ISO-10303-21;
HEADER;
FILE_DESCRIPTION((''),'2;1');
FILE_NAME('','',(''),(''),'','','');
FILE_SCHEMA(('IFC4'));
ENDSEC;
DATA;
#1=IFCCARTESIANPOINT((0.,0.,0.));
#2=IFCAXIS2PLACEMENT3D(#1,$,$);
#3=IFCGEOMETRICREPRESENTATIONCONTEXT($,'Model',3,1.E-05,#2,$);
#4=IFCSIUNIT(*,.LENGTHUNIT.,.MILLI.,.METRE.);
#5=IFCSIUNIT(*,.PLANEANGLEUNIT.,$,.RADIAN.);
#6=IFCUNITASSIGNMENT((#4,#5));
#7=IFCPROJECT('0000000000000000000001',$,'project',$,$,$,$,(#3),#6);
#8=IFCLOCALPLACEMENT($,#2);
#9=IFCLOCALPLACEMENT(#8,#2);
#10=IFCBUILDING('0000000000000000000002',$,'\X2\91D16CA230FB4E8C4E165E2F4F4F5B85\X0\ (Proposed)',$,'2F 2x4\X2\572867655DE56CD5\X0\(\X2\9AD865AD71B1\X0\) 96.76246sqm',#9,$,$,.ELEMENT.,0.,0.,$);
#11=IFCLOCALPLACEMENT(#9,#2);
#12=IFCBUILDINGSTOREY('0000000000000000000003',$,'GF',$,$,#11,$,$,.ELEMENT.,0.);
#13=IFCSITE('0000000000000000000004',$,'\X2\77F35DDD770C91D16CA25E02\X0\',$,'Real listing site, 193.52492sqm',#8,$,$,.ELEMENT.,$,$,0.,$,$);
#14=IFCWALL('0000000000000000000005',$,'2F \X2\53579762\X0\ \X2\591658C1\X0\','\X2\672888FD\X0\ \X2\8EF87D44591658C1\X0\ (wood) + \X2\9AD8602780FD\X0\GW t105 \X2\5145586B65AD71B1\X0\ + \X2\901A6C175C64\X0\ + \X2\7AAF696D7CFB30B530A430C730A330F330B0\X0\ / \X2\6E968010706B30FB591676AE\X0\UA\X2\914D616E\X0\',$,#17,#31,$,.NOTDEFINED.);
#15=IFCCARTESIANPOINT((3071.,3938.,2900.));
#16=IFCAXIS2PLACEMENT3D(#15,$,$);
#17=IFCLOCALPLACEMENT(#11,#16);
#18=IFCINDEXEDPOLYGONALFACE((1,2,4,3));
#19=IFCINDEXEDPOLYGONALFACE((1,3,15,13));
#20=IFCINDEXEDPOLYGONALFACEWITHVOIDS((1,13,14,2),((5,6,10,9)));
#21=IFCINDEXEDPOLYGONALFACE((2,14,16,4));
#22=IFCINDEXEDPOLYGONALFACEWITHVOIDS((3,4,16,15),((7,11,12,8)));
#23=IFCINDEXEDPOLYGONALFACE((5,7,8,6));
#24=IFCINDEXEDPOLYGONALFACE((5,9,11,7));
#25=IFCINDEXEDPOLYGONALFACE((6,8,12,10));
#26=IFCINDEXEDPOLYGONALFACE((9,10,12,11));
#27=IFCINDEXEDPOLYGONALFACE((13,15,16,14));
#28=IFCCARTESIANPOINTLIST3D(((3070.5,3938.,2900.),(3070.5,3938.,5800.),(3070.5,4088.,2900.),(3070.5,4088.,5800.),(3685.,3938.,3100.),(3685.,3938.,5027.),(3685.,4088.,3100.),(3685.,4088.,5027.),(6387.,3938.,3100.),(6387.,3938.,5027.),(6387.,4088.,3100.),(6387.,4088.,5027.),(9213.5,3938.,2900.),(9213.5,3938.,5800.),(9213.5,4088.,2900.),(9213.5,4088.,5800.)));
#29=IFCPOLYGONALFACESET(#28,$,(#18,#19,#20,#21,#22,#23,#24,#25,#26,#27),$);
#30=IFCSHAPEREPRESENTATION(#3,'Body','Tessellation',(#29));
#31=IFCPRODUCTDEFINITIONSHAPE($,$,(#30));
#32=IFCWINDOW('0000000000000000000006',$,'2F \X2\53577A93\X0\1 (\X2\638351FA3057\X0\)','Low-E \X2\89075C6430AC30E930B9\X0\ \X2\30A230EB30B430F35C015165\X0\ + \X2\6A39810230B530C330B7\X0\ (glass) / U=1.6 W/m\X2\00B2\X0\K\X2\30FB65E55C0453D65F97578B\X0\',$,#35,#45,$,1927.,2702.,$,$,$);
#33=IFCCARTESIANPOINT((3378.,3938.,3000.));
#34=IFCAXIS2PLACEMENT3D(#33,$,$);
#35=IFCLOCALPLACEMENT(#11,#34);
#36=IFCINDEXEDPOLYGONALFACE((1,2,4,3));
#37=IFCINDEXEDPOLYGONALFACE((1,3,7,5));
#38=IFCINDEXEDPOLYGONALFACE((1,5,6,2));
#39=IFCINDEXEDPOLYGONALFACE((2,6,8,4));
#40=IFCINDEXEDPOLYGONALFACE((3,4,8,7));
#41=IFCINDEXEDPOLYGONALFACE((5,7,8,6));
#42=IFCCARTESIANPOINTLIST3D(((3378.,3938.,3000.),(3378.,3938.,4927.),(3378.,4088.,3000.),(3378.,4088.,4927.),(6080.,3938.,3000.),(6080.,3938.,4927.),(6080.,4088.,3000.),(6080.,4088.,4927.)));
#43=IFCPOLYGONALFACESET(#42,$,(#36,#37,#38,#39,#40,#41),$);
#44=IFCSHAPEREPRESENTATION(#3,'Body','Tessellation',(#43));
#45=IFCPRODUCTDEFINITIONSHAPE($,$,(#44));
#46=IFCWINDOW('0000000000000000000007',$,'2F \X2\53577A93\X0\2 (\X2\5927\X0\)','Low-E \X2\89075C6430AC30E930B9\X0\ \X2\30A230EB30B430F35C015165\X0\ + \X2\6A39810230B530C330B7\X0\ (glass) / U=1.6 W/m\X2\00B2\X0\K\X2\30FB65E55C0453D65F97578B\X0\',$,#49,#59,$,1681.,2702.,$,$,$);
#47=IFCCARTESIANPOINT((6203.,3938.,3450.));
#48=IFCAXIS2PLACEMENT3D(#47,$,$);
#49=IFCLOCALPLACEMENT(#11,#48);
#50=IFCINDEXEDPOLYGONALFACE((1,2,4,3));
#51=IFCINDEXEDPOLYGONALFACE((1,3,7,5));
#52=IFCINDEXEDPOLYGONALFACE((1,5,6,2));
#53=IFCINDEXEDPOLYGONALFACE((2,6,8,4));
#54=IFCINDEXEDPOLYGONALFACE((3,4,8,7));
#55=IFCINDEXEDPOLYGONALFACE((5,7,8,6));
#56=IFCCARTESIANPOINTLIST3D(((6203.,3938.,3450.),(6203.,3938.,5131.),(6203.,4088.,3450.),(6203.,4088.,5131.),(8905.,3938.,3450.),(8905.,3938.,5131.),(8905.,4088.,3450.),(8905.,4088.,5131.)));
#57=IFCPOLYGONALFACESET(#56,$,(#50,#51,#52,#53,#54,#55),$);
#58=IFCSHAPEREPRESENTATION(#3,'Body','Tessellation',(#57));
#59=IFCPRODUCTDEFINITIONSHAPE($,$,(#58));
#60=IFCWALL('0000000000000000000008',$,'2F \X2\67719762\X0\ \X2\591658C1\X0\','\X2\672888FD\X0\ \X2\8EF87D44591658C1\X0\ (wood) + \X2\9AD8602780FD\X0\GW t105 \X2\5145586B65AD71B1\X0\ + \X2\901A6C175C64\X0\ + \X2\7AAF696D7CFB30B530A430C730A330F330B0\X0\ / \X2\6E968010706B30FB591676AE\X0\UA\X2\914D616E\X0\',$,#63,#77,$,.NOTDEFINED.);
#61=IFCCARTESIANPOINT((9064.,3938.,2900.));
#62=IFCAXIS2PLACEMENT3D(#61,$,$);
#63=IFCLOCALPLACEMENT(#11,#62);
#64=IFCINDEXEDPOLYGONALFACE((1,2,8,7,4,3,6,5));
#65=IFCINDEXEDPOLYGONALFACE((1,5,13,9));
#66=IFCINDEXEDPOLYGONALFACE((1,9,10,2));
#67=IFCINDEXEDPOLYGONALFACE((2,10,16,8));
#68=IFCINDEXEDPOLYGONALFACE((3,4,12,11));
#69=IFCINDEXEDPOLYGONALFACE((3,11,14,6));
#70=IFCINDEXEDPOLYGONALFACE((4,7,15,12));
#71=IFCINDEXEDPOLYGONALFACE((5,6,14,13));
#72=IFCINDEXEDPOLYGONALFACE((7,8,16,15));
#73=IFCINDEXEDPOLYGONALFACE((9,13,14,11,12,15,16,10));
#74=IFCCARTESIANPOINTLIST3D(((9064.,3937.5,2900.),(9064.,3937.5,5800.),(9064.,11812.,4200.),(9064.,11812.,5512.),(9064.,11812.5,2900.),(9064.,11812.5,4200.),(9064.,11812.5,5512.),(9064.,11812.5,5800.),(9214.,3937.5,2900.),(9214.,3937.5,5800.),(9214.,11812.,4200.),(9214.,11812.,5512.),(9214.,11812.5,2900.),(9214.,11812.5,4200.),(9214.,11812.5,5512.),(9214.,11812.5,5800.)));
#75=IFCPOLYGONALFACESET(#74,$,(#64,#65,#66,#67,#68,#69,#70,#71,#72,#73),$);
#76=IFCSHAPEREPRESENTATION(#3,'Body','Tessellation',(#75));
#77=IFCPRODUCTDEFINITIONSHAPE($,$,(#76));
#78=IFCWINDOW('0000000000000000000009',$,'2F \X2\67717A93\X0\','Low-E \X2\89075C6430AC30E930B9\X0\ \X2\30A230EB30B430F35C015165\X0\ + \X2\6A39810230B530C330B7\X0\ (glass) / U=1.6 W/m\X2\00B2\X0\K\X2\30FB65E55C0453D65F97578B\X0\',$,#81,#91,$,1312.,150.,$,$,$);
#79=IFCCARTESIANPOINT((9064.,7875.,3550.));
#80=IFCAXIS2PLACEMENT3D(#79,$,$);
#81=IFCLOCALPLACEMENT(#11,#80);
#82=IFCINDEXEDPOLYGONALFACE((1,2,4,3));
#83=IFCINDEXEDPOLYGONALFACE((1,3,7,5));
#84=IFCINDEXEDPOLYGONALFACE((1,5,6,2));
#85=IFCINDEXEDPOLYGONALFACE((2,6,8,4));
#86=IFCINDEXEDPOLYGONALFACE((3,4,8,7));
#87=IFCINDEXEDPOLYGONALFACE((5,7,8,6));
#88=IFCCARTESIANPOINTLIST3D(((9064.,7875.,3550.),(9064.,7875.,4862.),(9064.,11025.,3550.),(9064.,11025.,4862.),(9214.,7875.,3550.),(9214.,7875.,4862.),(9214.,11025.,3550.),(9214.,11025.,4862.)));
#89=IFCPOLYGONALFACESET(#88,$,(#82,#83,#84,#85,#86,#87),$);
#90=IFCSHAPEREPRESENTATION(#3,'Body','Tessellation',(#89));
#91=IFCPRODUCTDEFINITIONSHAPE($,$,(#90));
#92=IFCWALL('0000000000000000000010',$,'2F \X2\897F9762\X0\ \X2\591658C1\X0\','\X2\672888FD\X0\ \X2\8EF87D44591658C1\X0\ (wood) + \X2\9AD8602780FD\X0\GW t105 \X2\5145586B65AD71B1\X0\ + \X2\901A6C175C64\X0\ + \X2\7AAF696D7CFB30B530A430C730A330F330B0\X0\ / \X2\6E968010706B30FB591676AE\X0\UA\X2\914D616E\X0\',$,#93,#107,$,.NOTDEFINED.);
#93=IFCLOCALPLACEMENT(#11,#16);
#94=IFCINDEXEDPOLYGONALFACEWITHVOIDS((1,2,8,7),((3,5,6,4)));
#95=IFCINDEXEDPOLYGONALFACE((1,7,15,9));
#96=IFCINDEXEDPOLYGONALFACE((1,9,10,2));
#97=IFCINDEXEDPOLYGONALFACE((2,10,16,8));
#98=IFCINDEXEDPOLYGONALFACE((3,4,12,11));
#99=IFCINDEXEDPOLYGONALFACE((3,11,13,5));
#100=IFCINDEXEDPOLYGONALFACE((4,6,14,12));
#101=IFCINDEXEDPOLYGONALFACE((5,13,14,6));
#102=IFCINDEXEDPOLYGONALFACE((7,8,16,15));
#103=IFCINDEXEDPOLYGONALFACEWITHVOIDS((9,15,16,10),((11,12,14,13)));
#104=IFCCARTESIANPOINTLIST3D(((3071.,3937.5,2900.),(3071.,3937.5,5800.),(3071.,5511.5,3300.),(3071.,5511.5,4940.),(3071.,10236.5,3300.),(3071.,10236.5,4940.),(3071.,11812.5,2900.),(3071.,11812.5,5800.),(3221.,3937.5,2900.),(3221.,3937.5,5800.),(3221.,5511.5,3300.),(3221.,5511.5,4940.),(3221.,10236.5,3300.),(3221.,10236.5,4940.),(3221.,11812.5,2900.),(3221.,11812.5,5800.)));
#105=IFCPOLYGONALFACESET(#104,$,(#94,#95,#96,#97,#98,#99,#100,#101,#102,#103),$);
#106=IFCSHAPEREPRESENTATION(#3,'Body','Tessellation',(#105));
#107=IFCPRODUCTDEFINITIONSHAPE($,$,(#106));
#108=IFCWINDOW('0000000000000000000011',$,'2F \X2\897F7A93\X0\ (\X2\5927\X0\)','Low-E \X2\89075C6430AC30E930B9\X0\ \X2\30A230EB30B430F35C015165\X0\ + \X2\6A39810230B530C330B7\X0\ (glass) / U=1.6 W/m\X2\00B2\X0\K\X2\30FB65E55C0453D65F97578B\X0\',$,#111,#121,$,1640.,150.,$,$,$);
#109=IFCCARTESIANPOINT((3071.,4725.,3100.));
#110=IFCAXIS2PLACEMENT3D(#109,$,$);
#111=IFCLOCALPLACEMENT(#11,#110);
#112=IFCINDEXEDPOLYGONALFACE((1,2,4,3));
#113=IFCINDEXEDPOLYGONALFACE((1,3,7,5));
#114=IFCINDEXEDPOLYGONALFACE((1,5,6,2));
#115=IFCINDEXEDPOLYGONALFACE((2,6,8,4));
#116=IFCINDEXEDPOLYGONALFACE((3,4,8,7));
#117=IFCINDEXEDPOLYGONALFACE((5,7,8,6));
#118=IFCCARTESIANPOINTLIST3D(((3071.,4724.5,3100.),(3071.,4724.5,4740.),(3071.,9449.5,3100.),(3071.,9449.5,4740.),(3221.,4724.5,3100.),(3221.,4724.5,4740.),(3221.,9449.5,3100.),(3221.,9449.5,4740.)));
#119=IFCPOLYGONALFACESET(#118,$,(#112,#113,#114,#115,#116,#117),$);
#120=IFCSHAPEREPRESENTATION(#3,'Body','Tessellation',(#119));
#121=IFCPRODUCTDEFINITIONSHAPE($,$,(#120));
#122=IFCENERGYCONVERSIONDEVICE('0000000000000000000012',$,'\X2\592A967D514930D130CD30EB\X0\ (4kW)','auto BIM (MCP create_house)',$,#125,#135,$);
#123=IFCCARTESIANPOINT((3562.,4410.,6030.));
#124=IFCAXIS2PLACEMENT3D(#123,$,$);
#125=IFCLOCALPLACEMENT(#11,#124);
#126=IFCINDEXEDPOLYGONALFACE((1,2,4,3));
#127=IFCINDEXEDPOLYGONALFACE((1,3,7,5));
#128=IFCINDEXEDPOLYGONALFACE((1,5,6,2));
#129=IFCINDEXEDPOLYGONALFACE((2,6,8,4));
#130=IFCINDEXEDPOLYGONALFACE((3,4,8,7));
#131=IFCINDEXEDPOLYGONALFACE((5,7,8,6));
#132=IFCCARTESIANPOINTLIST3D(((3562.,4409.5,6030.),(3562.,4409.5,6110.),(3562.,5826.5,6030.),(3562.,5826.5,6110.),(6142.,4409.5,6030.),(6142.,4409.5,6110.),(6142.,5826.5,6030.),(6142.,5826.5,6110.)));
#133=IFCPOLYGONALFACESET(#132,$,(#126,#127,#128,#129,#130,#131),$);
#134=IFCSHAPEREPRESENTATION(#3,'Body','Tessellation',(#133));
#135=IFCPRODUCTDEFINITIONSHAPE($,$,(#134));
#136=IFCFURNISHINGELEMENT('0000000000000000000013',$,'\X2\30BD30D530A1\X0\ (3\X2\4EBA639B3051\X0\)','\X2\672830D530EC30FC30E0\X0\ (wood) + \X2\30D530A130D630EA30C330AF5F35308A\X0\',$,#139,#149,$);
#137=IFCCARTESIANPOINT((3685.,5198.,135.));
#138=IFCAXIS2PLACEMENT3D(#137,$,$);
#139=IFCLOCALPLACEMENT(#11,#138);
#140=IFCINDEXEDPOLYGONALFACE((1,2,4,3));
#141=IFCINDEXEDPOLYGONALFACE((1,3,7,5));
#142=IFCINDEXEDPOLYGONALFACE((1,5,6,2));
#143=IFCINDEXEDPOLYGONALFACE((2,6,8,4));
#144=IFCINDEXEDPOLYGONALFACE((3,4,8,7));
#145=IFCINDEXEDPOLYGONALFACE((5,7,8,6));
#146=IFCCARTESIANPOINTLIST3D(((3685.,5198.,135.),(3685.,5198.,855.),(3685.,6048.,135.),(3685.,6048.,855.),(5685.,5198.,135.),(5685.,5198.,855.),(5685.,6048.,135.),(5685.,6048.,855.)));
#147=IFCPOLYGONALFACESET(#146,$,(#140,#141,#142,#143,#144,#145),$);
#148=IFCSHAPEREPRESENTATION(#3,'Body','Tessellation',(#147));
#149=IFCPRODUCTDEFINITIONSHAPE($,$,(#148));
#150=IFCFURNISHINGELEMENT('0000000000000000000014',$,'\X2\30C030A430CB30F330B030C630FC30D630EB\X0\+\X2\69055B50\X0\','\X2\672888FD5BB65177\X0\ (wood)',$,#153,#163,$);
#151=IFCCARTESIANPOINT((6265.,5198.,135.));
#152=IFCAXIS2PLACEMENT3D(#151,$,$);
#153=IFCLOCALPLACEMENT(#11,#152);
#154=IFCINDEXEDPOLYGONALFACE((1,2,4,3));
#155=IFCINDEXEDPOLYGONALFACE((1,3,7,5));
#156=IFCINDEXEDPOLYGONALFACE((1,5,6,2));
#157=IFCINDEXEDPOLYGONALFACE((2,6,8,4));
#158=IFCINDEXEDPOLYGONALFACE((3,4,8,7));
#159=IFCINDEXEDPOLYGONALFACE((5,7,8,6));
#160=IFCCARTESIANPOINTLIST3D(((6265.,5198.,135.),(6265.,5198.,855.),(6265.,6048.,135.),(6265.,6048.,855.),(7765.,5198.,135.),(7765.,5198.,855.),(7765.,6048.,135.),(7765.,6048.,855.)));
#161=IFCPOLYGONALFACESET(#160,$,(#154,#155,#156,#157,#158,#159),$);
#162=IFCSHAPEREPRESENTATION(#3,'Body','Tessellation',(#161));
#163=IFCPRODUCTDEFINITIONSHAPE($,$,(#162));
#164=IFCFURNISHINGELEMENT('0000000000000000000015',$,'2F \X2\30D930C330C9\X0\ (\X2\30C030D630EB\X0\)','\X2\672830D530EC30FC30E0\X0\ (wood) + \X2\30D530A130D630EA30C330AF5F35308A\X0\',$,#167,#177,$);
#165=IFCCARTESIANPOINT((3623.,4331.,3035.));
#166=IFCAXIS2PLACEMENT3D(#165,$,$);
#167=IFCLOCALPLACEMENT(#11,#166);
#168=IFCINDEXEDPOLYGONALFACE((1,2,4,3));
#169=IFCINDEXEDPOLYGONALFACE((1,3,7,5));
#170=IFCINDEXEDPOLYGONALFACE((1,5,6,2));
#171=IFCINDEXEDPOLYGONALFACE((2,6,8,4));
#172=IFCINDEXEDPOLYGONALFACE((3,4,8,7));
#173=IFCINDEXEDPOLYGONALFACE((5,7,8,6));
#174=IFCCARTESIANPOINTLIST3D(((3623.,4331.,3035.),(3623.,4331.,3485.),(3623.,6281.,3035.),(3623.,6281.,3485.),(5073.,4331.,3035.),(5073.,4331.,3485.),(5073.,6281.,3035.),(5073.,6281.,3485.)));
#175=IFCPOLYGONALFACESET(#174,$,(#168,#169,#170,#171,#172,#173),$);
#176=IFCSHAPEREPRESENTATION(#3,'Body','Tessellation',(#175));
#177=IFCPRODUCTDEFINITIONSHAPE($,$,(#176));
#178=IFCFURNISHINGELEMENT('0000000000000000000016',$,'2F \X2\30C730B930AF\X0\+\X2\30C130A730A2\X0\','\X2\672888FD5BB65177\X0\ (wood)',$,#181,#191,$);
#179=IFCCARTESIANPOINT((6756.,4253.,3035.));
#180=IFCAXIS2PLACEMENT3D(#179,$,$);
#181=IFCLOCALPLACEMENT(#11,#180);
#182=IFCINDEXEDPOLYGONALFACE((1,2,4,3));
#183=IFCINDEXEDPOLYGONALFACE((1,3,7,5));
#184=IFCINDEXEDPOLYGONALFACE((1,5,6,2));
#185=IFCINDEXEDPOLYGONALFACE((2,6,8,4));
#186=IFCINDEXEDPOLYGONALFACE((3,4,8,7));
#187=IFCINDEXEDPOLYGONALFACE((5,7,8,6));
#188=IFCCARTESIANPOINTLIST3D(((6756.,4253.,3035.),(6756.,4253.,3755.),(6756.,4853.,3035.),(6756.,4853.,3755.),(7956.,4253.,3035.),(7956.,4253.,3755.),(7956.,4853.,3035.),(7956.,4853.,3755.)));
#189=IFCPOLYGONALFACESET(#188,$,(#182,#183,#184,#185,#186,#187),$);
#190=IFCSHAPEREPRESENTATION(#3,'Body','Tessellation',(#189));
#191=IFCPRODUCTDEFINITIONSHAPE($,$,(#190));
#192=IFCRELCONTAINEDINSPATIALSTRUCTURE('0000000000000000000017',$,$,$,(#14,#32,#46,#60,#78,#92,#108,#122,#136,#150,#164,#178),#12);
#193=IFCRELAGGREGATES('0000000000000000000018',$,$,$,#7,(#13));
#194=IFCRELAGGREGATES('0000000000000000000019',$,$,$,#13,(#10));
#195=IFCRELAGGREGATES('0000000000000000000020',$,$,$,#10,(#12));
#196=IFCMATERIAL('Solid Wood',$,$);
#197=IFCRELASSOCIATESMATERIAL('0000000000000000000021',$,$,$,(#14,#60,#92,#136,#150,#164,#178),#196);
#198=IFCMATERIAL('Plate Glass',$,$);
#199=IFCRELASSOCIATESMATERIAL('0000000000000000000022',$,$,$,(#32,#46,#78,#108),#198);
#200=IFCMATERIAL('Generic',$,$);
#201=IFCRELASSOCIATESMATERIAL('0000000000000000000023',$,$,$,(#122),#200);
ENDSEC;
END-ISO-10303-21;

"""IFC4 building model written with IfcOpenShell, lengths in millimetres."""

from ifc_helpers import new_model, si_unit, frame, frame_2d, origin, place, context, project, spatial, rectangle, extrude, material, element, fill, save


model = new_model("IFC4")

# Units and contexts
model_context = context("Model", 3, precision=1e-05, world=origin())
ifc_project = project(units=[si_unit("LENGTHUNIT", "METRE", prefix="MILLI"), si_unit("PLANEANGLEUNIT", "RADIAN")], contexts=[model_context])

# Site, building, storey
site_placement = place(None, origin())
site = spatial("IfcSite", under=ifc_project, at=site_placement, Name="石川県金沢市", ObjectType="Real listing site, 193.52492sqm", CompositionType="ELEMENT", RefElevation=0.0)
building_placement = place(site_placement, origin())
building = spatial("IfcBuilding", under=site, at=building_placement, Name="金沢・二世帯住宅 (Proposed)", ObjectType="2F 2x4在来工法(高断熱) 96.76246sqm", CompositionType="ELEMENT", ElevationOfRefHeight=0.0, ElevationOfTerrain=0.0)
storey_placement = place(building_placement, origin())
storey = spatial("IfcBuildingStorey", under=building, at=storey_placement, Name="GF", CompositionType="ELEMENT", Elevation=0.0)

# Shared definitions
ifc_material_1 = material(Name="Solid Wood")

# Wall, openings, windows
wall_1_placement = place(storey_placement, frame((3071.0, 3938.0, 2900.0)))
wall_1 = element("IfcWall", 1, at=wall_1_placement, inside=storey, material=ifc_material_1, Name="2F 南面 外壁", Description="木製 軸組外壁 (wood) + 高性能GW t105 充填断熱 + 通気層 + 窯業系サイディング / 準耐火・外皮UA配慮", PredefinedType="NOTDEFINED", context=model_context, shape_type="SweptSolid", body=[
    extrude(rectangle(XDim=6143.0, YDim=150.0, at=frame_2d((3071.0, 75.0))), frame((3071.0, 3938.0, 2900.0)), (0.0, 0.0, 1.0), 2900.0),
])
opening_1_placement = place(storey_placement, frame((3378.0, 3938.0, 3000.0)))
opening_1 = element("IfcOpeningElement", 2, at=opening_1_placement, cuts=wall_1, PredefinedType="NOTDEFINED", context=model_context, shape_type="SweptSolid", body=[
    extrude(rectangle(XDim=2702.0, YDim=150.0, at=frame_2d((1351.0, 75.0))), frame((3378.0, 3938.0, 3000.0)), (0.0, 0.0, 1.0), 1927.0),
])
opening_2_placement = place(storey_placement, frame((6203.0, 3938.0, 3450.0)))
opening_2 = element("IfcOpeningElement", 3, at=opening_2_placement, cuts=wall_1, PredefinedType="NOTDEFINED", context=model_context, shape_type="SweptSolid", body=[
    extrude(rectangle(XDim=2702.0, YDim=150.0, at=frame_2d((1351.0, 75.0))), frame((6203.0, 3938.0, 3450.0)), (0.0, 0.0, 1.0), 1681.0),
])
ifc_material_2 = material(Name="Plate Glass")
window_1_placement = place(storey_placement, frame((3378.0, 3938.0, 3000.0)))
window_1 = element("IfcWindow", 4, at=window_1_placement, inside=storey, material=ifc_material_2, Name="2F 南窓1 (掃出し)", Description="Low-E 複層ガラス アルゴン封入 + 樹脂サッシ (glass) / U=1.6 W/m²K・日射取得型", OverallHeight=1927.0, OverallWidth=2702.0, context=model_context, shape_type="SweptSolid", body=[
    extrude(rectangle(XDim=2702.0, YDim=150.0, at=frame_2d((1351.0, 75.0))), frame((3378.0, 3938.0, 3000.0)), (0.0, 0.0, 1.0), 1927.0),
])
fill(opening_1, window_1)
window_2_placement = place(storey_placement, frame((6203.0, 3938.0, 3450.0)))
window_2 = element("IfcWindow", 5, at=window_2_placement, inside=storey, material=ifc_material_2, Name="2F 南窓2 (大)", Description="Low-E 複層ガラス アルゴン封入 + 樹脂サッシ (glass) / U=1.6 W/m²K・日射取得型", OverallHeight=1681.0, OverallWidth=2702.0, context=model_context, shape_type="SweptSolid", body=[
    extrude(rectangle(XDim=2702.0, YDim=150.0, at=frame_2d((1351.0, 75.0))), frame((6203.0, 3938.0, 3450.0)), (0.0, 0.0, 1.0), 1681.0),
])
fill(opening_2, window_2)

# Walls, openings, windows
wall_2_placement = place(storey_placement, frame((9064.0, 3938.0, 2900.0)))
wall_2 = element("IfcWall", 6, at=wall_2_placement, inside=storey, material=ifc_material_1, Name="2F 東面 外壁", Description="木製 軸組外壁 (wood) + 高性能GW t105 充填断熱 + 通気層 + 窯業系サイディング / 準耐火・外皮UA配慮", PredefinedType="NOTDEFINED", context=model_context, shape_type="SweptSolid", body=[
    extrude(rectangle(XDim=150.0, YDim=7875.0, at=frame_2d((75.0, 3937.0))), frame((9064.0, 3938.0, 2900.0)), (0.0, 0.0, 1.0), 2900.0),
])
opening_3_placement = place(storey_placement, frame((9064.0, 7875.0, 3550.0)))
opening_3 = element("IfcOpeningElement", 7, at=opening_3_placement, cuts=wall_2, PredefinedType="NOTDEFINED", context=model_context, shape_type="SweptSolid", body=[
    extrude(rectangle(XDim=150.0, YDim=3150.0, at=frame_2d((75.0, 1575.0))), frame((9064.0, 7875.0, 3550.0)), (0.0, 0.0, 1.0), 1312.0),
])
window_3_placement = place(storey_placement, frame((9064.0, 7875.0, 3550.0)))
window_3 = element("IfcWindow", 8, at=window_3_placement, inside=storey, material=ifc_material_2, Name="2F 東窓", Description="Low-E 複層ガラス アルゴン封入 + 樹脂サッシ (glass) / U=1.6 W/m²K・日射取得型", OverallHeight=1312.0, OverallWidth=150.0, context=model_context, shape_type="SweptSolid", body=[
    extrude(rectangle(XDim=150.0, YDim=3150.0, at=frame_2d((75.0, 1575.0))), frame((9064.0, 7875.0, 3550.0)), (0.0, 0.0, 1.0), 1312.0),
])
fill(opening_3, window_3)
wall_3_placement = place(storey_placement, frame((3071.0, 3938.0, 2900.0)))
wall_3 = element("IfcWall", 9, at=wall_3_placement, inside=storey, material=ifc_material_1, Name="2F 西面 外壁", Description="木製 軸組外壁 (wood) + 高性能GW t105 充填断熱 + 通気層 + 窯業系サイディング / 準耐火・外皮UA配慮", PredefinedType="NOTDEFINED", context=model_context, shape_type="SweptSolid", body=[
    extrude(rectangle(XDim=150.0, YDim=7875.0, at=frame_2d((75.0, 3937.0))), frame((3071.0, 3938.0, 2900.0)), (0.0, 0.0, 1.0), 2900.0),
])
opening_4_placement = place(storey_placement, frame((3071.0, 4725.0, 3100.0)))
opening_4 = element("IfcOpeningElement", 10, at=opening_4_placement, cuts=wall_3, PredefinedType="NOTDEFINED", context=model_context, shape_type="SweptSolid", body=[
    extrude(rectangle(XDim=150.0, YDim=4725.0, at=frame_2d((75.0, 2362.0))), frame((3071.0, 4725.0, 3100.0)), (0.0, 0.0, 1.0), 1640.0),
])
window_4_placement = place(storey_placement, frame((3071.0, 4725.0, 3100.0)))
window_4 = element("IfcWindow", 11, at=window_4_placement, inside=storey, material=ifc_material_2, Name="2F 西窓 (大)", Description="Low-E 複層ガラス アルゴン封入 + 樹脂サッシ (glass) / U=1.6 W/m²K・日射取得型", OverallHeight=1640.0, OverallWidth=150.0, context=model_context, shape_type="SweptSolid", body=[
    extrude(rectangle(XDim=150.0, YDim=4725.0, at=frame_2d((75.0, 2362.0))), frame((3071.0, 4725.0, 3100.0)), (0.0, 0.0, 1.0), 1640.0),
])
fill(opening_4, window_4)

# Shared definitions
ifc_material_3 = material(Name="Generic")

# Energy conversion device
energy_conversion_device_placement = place(storey_placement, frame((3562.0, 4410.0, 6030.0)))
element("IfcEnergyConversionDevice", 12, at=energy_conversion_device_placement, inside=storey, material=ifc_material_3, Name="太陽光パネル (4kW)", Description="auto BIM (MCP create_house)", context=model_context, shape_type="SweptSolid", body=[
    extrude(rectangle(XDim=2580.0, YDim=1417.0, at=frame_2d((1290.0, 708.0))), frame((3562.0, 4410.0, 6030.0)), (0.0, 0.0, 1.0), 80.0),
])

# Furnishing elements
furnishing_1_placement = place(storey_placement, frame((3685.0, 5198.0, 135.0)))
element("IfcFurnishingElement", 13, at=furnishing_1_placement, inside=storey, material=ifc_material_1, Name="ソファ (3人掛け)", Description="木フレーム (wood) + ファブリック張り", context=model_context, shape_type="SweptSolid", body=[
    extrude(rectangle(XDim=2000.0, YDim=850.0, at=frame_2d((1000.0, 425.0))), frame((3685.0, 5198.0, 135.0)), (0.0, 0.0, 1.0), 720.0),
])
furnishing_2_placement = place(storey_placement, frame((6265.0, 5198.0, 135.0)))
element("IfcFurnishingElement", 14, at=furnishing_2_placement, inside=storey, material=ifc_material_1, Name="ダイニングテーブル+椅子", Description="木製家具 (wood)", context=model_context, shape_type="SweptSolid", body=[
    extrude(rectangle(XDim=1500.0, YDim=850.0, at=frame_2d((750.0, 425.0))), frame((6265.0, 5198.0, 135.0)), (0.0, 0.0, 1.0), 720.0),
])
furnishing_3_placement = place(storey_placement, frame((3623.0, 4331.0, 3035.0)))
element("IfcFurnishingElement", 15, at=furnishing_3_placement, inside=storey, material=ifc_material_1, Name="2F ベッド (ダブル)", Description="木フレーム (wood) + ファブリック張り", context=model_context, shape_type="SweptSolid", body=[
    extrude(rectangle(XDim=1450.0, YDim=1950.0, at=frame_2d((725.0, 975.0))), frame((3623.0, 4331.0, 3035.0)), (0.0, 0.0, 1.0), 450.0),
])
furnishing_4_placement = place(storey_placement, frame((6756.0, 4253.0, 3035.0)))
element("IfcFurnishingElement", 16, at=furnishing_4_placement, inside=storey, material=ifc_material_1, Name="2F デスク+チェア", Description="木製家具 (wood)", context=model_context, shape_type="SweptSolid", body=[
    extrude(rectangle(XDim=1200.0, YDim=600.0, at=frame_2d((600.0, 300.0))), frame((6756.0, 4253.0, 3035.0)), (0.0, 0.0, 1.0), 720.0),
])

save(model, "model.ifc")
